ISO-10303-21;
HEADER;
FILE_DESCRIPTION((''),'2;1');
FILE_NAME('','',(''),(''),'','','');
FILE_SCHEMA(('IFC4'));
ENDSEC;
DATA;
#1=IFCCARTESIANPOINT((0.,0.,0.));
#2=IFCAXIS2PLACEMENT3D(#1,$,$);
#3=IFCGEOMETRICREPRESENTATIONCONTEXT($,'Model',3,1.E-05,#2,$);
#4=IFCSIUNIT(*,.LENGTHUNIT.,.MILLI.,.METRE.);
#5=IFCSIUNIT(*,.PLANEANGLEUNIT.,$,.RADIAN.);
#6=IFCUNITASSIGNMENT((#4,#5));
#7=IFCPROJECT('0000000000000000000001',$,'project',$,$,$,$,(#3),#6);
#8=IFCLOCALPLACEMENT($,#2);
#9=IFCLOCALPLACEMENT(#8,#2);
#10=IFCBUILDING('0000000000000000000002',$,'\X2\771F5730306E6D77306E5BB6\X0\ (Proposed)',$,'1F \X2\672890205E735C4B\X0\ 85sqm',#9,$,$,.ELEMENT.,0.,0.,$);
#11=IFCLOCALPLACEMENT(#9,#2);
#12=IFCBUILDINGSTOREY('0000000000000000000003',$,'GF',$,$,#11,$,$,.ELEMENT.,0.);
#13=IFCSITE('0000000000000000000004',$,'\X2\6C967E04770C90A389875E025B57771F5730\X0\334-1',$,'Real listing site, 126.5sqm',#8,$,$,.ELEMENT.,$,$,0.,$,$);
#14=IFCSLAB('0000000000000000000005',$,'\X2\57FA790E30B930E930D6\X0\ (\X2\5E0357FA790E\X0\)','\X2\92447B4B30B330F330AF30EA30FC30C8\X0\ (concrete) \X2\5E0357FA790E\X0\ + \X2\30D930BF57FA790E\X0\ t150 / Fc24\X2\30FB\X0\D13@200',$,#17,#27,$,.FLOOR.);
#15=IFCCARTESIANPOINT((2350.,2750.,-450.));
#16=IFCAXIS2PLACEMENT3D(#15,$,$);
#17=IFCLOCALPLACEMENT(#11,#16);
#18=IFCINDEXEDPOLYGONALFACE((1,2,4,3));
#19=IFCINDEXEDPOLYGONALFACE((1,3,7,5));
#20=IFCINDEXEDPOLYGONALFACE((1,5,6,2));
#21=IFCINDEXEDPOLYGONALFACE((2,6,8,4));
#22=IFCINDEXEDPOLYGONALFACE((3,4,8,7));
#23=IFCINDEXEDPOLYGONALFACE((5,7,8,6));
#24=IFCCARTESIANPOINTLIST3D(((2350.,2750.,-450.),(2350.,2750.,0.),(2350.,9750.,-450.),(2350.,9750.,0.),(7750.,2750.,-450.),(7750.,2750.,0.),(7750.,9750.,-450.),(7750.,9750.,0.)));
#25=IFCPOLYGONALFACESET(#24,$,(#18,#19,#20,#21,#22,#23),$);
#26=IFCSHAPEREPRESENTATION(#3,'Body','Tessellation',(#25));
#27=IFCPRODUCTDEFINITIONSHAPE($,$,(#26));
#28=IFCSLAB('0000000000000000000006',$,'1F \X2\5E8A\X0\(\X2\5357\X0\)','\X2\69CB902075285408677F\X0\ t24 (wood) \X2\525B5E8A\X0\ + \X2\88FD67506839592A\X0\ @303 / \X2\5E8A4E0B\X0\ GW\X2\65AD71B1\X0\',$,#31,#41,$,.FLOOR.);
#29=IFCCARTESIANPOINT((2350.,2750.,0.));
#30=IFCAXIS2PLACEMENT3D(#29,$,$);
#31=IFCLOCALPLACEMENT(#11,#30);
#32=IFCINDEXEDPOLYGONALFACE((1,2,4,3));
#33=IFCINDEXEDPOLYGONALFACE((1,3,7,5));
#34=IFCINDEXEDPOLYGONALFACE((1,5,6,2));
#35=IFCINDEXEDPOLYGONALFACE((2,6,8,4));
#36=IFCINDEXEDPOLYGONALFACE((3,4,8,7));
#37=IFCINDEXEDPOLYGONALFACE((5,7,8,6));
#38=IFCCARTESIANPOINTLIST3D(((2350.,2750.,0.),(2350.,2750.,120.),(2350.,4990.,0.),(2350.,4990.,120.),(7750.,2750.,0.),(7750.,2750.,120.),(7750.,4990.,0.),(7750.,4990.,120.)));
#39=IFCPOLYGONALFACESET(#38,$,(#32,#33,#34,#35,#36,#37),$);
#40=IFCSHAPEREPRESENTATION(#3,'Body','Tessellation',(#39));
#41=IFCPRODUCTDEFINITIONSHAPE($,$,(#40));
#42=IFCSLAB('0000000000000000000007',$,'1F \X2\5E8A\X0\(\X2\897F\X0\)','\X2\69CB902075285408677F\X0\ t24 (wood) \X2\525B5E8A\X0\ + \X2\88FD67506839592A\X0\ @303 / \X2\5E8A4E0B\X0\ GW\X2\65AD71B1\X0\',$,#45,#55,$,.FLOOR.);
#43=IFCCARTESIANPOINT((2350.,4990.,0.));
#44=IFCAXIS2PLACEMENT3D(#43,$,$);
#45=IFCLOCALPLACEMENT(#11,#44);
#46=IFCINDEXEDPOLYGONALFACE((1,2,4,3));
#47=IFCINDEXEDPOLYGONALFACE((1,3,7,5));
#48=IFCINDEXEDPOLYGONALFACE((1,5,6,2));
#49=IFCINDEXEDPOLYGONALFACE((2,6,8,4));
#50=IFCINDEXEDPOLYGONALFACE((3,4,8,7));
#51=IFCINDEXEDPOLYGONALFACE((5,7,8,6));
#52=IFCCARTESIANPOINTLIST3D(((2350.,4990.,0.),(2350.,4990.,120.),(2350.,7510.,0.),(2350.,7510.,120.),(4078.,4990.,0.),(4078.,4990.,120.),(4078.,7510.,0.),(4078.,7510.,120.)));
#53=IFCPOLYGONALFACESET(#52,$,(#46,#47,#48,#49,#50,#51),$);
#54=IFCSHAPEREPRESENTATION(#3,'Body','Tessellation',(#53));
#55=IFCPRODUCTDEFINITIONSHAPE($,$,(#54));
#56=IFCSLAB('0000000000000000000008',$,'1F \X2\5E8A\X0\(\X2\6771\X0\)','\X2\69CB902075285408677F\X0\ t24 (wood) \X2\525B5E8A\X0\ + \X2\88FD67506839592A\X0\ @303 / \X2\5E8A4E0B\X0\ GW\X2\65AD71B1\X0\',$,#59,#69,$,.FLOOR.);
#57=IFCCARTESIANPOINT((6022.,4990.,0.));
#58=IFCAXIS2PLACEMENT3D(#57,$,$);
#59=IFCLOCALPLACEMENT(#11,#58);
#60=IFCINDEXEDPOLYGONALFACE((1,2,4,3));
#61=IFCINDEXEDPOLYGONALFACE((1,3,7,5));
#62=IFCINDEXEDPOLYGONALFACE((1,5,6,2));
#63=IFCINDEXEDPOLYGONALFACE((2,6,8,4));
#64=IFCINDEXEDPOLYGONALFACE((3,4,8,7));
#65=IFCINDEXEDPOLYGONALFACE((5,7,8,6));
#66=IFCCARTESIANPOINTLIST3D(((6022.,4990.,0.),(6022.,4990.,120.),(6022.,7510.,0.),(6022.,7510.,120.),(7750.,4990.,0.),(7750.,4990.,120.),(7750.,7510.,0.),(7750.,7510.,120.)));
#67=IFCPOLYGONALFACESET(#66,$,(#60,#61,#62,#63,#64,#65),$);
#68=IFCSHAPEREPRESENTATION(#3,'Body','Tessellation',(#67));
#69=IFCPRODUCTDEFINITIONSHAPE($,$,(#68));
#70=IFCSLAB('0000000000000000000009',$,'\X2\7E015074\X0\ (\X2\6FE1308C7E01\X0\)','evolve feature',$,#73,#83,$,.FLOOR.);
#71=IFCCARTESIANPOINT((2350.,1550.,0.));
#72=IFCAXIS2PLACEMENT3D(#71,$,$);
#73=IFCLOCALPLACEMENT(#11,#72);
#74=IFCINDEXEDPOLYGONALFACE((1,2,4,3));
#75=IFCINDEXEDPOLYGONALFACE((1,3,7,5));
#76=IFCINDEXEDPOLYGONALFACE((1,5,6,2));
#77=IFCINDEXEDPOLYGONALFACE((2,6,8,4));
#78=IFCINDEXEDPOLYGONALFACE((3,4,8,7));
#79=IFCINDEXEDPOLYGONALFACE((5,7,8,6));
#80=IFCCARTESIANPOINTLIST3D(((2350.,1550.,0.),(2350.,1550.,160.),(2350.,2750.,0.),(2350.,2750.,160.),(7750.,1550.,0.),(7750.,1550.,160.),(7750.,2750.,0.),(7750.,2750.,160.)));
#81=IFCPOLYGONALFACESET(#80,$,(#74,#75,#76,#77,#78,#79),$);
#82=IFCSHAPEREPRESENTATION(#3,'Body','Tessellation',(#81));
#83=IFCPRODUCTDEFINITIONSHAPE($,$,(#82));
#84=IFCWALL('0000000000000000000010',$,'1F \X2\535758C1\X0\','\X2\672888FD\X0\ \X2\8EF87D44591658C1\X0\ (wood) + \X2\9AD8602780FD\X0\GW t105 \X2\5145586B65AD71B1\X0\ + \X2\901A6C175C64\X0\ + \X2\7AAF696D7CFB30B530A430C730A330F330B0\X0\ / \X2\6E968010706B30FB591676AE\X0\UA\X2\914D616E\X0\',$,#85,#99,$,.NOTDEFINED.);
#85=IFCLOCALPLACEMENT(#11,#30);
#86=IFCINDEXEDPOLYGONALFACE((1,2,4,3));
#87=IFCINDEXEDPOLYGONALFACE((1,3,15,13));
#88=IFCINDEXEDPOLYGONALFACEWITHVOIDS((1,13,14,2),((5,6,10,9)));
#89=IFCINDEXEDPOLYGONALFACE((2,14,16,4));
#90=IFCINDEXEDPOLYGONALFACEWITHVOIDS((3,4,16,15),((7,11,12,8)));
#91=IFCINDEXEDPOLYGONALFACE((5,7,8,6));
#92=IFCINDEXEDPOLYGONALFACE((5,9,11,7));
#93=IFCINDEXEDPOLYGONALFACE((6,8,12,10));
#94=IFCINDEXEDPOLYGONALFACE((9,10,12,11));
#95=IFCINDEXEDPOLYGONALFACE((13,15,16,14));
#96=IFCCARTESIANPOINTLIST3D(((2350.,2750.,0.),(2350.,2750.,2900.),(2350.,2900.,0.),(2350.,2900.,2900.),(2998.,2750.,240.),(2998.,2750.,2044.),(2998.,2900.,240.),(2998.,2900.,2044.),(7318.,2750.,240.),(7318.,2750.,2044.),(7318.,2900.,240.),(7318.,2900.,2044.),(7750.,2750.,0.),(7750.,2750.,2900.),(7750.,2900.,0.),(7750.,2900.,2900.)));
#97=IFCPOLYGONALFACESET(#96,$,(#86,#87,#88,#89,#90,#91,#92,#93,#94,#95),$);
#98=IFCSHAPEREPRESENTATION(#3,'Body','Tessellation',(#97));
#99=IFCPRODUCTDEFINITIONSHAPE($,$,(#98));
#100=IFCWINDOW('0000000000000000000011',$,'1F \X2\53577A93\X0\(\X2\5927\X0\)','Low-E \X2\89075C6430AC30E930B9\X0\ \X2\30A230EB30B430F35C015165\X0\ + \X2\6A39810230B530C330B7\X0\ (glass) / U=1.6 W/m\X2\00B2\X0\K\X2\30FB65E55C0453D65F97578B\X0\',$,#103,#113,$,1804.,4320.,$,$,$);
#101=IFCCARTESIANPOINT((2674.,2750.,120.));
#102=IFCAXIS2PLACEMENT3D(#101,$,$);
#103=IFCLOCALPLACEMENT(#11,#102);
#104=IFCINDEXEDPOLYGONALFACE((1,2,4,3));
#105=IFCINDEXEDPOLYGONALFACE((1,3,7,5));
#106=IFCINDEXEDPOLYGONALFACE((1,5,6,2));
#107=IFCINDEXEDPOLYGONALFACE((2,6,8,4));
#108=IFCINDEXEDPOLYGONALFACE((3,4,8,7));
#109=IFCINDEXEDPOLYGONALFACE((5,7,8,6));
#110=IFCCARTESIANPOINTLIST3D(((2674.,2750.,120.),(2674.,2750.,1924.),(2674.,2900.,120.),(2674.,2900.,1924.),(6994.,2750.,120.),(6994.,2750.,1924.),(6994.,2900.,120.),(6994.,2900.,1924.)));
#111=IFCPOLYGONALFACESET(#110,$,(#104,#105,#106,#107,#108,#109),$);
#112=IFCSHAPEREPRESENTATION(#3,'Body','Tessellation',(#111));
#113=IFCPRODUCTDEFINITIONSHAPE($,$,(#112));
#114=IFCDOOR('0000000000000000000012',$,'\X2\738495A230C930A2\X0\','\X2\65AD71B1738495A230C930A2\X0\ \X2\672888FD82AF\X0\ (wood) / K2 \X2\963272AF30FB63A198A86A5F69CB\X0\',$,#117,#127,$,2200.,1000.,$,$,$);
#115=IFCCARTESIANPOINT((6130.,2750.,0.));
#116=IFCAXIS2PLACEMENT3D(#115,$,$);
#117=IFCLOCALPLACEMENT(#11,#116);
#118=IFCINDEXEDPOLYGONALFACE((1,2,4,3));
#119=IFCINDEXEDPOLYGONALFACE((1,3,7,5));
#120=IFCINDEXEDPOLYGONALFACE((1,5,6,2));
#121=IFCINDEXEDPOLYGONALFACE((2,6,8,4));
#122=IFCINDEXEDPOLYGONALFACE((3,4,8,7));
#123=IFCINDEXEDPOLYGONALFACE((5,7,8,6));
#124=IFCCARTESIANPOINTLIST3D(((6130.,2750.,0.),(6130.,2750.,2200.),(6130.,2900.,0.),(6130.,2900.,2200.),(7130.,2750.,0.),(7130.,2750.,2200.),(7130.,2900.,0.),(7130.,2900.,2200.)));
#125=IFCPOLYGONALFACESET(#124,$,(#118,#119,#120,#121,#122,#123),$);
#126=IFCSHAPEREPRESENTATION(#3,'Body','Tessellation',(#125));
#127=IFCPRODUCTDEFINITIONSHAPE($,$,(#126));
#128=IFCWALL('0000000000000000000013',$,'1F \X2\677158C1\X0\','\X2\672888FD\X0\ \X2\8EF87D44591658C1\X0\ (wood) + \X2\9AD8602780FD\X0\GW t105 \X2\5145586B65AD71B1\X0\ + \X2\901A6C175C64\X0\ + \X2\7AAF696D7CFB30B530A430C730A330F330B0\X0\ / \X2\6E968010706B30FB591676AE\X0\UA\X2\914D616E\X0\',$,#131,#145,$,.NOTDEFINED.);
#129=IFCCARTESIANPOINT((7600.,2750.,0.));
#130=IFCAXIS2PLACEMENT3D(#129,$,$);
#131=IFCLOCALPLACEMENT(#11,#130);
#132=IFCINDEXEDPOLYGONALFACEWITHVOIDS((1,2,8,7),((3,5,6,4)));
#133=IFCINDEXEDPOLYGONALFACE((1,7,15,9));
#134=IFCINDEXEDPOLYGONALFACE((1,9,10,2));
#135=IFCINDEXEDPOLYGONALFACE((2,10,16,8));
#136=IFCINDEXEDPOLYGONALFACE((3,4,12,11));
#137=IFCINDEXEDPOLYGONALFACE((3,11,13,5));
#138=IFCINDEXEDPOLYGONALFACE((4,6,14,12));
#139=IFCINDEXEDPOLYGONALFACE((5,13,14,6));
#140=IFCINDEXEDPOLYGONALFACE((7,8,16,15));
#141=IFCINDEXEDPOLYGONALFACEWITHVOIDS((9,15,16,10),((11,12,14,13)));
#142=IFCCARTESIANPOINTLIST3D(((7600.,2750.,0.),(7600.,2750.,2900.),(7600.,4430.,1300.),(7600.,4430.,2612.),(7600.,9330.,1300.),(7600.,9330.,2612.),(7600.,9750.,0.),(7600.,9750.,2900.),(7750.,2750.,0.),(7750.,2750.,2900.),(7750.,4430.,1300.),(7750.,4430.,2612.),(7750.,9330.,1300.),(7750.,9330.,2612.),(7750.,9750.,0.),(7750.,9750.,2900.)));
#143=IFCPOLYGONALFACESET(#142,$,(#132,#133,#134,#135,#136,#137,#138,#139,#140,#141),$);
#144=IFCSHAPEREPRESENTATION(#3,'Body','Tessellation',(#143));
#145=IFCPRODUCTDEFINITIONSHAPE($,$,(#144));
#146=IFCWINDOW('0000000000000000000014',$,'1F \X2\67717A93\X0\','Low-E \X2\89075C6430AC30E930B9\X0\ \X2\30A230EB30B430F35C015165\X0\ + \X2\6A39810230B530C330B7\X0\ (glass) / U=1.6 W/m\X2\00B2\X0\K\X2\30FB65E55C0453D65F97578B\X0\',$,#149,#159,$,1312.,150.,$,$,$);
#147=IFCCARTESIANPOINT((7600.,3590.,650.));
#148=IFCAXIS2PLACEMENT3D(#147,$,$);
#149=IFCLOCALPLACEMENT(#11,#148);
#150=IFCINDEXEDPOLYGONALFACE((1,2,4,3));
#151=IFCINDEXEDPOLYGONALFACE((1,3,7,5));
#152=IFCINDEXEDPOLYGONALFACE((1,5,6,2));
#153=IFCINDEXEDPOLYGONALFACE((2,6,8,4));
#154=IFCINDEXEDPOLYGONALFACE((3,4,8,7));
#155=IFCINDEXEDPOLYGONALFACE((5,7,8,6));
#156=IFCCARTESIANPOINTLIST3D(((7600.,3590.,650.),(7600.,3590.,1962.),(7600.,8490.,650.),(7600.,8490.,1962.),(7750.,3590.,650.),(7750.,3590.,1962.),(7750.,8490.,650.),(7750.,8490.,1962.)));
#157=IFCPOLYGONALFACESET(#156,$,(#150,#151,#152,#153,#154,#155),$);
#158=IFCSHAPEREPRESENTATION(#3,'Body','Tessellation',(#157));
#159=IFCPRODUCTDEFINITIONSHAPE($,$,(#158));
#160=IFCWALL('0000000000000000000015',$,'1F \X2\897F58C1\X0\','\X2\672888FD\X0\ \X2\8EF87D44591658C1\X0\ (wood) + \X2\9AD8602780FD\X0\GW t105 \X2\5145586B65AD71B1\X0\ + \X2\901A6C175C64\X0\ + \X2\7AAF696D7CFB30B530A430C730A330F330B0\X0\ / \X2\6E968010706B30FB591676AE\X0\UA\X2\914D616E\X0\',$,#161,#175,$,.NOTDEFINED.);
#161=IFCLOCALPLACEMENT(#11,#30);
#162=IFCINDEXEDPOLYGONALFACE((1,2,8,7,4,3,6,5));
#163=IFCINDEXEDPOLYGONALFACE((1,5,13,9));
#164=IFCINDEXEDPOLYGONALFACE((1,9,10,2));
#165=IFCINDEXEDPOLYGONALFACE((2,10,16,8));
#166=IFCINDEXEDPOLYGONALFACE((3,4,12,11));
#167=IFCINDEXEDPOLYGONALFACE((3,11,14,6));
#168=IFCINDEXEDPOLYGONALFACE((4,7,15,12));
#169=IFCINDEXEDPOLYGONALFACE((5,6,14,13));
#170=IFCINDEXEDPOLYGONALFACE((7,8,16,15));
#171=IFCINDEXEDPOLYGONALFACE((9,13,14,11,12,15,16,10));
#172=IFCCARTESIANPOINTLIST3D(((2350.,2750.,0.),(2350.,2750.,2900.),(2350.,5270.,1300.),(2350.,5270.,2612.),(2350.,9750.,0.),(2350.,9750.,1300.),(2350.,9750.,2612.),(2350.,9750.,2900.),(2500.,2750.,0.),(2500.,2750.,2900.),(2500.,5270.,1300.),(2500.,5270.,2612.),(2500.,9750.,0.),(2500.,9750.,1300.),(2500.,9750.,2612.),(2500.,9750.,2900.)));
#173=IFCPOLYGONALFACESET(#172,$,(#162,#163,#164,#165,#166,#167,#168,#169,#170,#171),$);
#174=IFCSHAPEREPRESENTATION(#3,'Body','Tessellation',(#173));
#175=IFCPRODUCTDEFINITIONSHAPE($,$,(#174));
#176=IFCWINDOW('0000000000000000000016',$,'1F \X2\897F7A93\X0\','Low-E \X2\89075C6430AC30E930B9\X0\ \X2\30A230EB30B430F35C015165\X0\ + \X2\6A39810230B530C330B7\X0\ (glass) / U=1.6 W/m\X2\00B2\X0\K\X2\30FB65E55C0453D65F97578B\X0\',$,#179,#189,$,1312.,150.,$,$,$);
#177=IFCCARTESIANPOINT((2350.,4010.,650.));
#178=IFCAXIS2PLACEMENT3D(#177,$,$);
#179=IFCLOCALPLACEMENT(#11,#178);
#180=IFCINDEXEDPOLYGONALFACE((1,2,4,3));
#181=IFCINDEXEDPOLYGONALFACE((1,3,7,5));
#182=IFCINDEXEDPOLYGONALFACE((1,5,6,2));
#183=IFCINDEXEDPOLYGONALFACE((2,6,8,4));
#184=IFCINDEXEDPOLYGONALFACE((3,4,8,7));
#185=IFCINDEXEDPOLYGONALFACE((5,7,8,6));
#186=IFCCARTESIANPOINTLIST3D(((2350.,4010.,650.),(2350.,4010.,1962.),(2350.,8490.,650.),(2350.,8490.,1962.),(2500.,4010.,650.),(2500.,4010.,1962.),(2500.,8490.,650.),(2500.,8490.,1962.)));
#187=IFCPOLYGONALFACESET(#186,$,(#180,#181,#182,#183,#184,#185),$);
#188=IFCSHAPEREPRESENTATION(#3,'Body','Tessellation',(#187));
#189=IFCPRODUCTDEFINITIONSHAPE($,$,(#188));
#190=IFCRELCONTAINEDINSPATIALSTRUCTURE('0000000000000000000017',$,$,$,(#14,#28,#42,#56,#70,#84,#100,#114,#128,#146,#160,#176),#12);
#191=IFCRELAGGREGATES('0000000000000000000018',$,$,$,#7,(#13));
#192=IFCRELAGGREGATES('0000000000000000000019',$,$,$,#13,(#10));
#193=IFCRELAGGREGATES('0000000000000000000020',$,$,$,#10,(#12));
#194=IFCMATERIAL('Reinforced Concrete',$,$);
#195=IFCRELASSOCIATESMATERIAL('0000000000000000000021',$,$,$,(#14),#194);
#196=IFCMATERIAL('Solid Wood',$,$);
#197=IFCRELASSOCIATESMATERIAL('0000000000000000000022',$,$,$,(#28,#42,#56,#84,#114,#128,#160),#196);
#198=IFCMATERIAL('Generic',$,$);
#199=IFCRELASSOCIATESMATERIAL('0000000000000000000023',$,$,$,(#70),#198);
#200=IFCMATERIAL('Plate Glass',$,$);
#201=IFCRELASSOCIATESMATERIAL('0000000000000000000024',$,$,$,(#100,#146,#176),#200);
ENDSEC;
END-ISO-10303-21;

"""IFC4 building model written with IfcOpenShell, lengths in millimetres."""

from ifc_helpers import new_model, si_unit, frame, frame_2d, origin, place, context, project, spatial, rectangle, extrude, material, element, fill, save


model = new_model("IFC4")

# Units and contexts
model_context = context("Model", 3, precision=1e-05, world=origin())
ifc_project = project(units=[si_unit("LENGTHUNIT", "METRE", prefix="MILLI"), si_unit("PLANEANGLEUNIT", "RADIAN")], contexts=[model_context])

# Site, building, storey
site_placement = place(None, origin())
site = spatial("IfcSite", under=ifc_project, at=site_placement, Name="沖縄県那覇市字真地334-1", ObjectType="Real listing site, 126.5sqm", CompositionType="ELEMENT", RefElevation=0.0)
building_placement = place(site_placement, origin())
building = spatial("IfcBuilding", under=site, at=building_placement, Name="真地の海の家 (Proposed)", ObjectType="1F 木造平屋 85sqm", CompositionType="ELEMENT", ElevationOfRefHeight=0.0, ElevationOfTerrain=0.0)
storey_placement = place(building_placement, origin())
storey = spatial("IfcBuildingStorey", under=building, at=storey_placement, Name="GF", CompositionType="ELEMENT", Elevation=0.0)

# Slabs
ifc_material_1 = material(Name="Reinforced Concrete")
slab_1_placement = place(storey_placement, frame((2350.0, 2750.0, -450.0)))
element("IfcSlab", 1, at=slab_1_placement, inside=storey, material=ifc_material_1, Name="基礎スラブ (布基礎)", Description="鉄筋コンクリート (concrete) 布基礎 + ベタ基礎 t150 / Fc24・D13@200", PredefinedType="FLOOR", context=model_context, shape_type="SweptSolid", body=[
    extrude(rectangle(XDim=5400.0, YDim=7000.0, at=frame_2d((2700.0, 3500.0))), frame((2350.0, 2750.0, -450.0)), (0.0, 0.0, 1.0), 450.0),
])
ifc_material_2 = material(Name="Solid Wood")
slab_2_placement = place(storey_placement, frame((2350.0, 2750.0, 0.0)))
element("IfcSlab", 2, at=slab_2_placement, inside=storey, material=ifc_material_2, Name="1F 床(南)", Description="構造用合板 t24 (wood) 剛床 + 製材根太 @303 / 床下 GW断熱", PredefinedType="FLOOR", context=model_context, shape_type="SweptSolid", body=[
    extrude(rectangle(XDim=5400.0, YDim=2240.0, at=frame_2d((2700.0, 1120.0))), frame((2350.0, 2750.0, 0.0)), (0.0, 0.0, 1.0), 120.0),
])
slab_3_placement = place(storey_placement, frame((2350.0, 4990.0, 0.0)))
element("IfcSlab", 3, at=slab_3_placement, inside=storey, material=ifc_material_2, Name="1F 床(西)", Description="構造用合板 t24 (wood) 剛床 + 製材根太 @303 / 床下 GW断熱", PredefinedType="FLOOR", context=model_context, shape_type="SweptSolid", body=[
    extrude(rectangle(XDim=1728.0, YDim=2520.0, at=frame_2d((864.0, 1260.0))), frame((2350.0, 4990.0, 0.0)), (0.0, 0.0, 1.0), 120.0),
])
slab_4_placement = place(storey_placement, frame((6022.0, 4990.0, 0.0)))
element("IfcSlab", 4, at=slab_4_placement, inside=storey, material=ifc_material_2, Name="1F 床(東)", Description="構造用合板 t24 (wood) 剛床 + 製材根太 @303 / 床下 GW断熱", PredefinedType="FLOOR", context=model_context, shape_type="SweptSolid", body=[
    extrude(rectangle(XDim=1728.0, YDim=2520.0, at=frame_2d((864.0, 1260.0))), frame((6022.0, 4990.0, 0.0)), (0.0, 0.0, 1.0), 120.0),
])
ifc_material_3 = material(Name="Generic")
slab_5_placement = place(storey_placement, frame((2350.0, 1550.0, 0.0)))
element("IfcSlab", 5, at=slab_5_placement, inside=storey, material=ifc_material_3, Name="縁側 (濡れ縁)", Description="evolve feature", PredefinedType="FLOOR", context=model_context, shape_type="SweptSolid", body=[
    extrude(rectangle(XDim=5400.0, YDim=1200.0, at=frame_2d((2700.0, 600.0))), frame((2350.0, 1550.0, 0.0)), (0.0, 0.0, 1.0), 160.0),
])

# Wall, openings, window, door
wall_1_placement = place(storey_placement, frame((2350.0, 2750.0, 0.0)))
wall_1 = element("IfcWall", 6, at=wall_1_placement, inside=storey, material=ifc_material_2, Name="1F 南壁", Description="木製 軸組外壁 (wood) + 高性能GW t105 充填断熱 + 通気層 + 窯業系サイディング / 準耐火・外皮UA配慮", PredefinedType="NOTDEFINED", context=model_context, shape_type="SweptSolid", body=[
    extrude(rectangle(XDim=5400.0, YDim=150.0, at=frame_2d((2700.0, 75.0))), frame((2350.0, 2750.0, 0.0)), (0.0, 0.0, 1.0), 2900.0),
])
opening_1_placement = place(storey_placement, frame((2674.0, 2750.0, 120.0)))
opening_1 = element("IfcOpeningElement", 7, at=opening_1_placement, cuts=wall_1, PredefinedType="NOTDEFINED", context=model_context, shape_type="SweptSolid", body=[
    extrude(rectangle(XDim=4320.0, YDim=150.0, at=frame_2d((2160.0, 75.0))), frame((2674.0, 2750.0, 120.0)), (0.0, 0.0, 1.0), 1804.0),
])
opening_2_placement = place(storey_placement, frame((6130.0, 2750.0, 0.0)))
opening_2 = element("IfcOpeningElement", 8, at=opening_2_placement, cuts=wall_1, PredefinedType="NOTDEFINED", context=model_context, shape_type="SweptSolid", body=[
    extrude(rectangle(XDim=1000.0, YDim=150.0, at=frame_2d((500.0, 75.0))), frame((6130.0, 2750.0, 0.0)), (0.0, 0.0, 1.0), 2200.0),
])
ifc_material_4 = material(Name="Plate Glass")
window_1_placement = place(storey_placement, frame((2674.0, 2750.0, 120.0)))
window_1 = element("IfcWindow", 9, at=window_1_placement, inside=storey, material=ifc_material_4, Name="1F 南窓(大)", Description="Low-E 複層ガラス アルゴン封入 + 樹脂サッシ (glass) / U=1.6 W/m²K・日射取得型", OverallHeight=1804.0, OverallWidth=4320.0, context=model_context, shape_type="SweptSolid", body=[
    extrude(rectangle(XDim=4320.0, YDim=150.0, at=frame_2d((2160.0, 75.0))), frame((2674.0, 2750.0, 120.0)), (0.0, 0.0, 1.0), 1804.0),
])
fill(opening_1, window_1)
door_placement = place(storey_placement, frame((6130.0, 2750.0, 0.0)))
door = element("IfcDoor", 10, at=door_placement, inside=storey, material=ifc_material_2, Name="玄関ドア", Description="断熱玄関ドア 木製芯 (wood) / K2 防犯・採風機構", OverallHeight=2200.0, OverallWidth=1000.0, context=model_context, shape_type="SweptSolid", body=[
    extrude(rectangle(XDim=1000.0, YDim=150.0, at=frame_2d((500.0, 75.0))), frame((6130.0, 2750.0, 0.0)), (0.0, 0.0, 1.0), 2200.0),
])
fill(opening_2, door)

# Walls, openings, windows
wall_2_placement = place(storey_placement, frame((7600.0, 2750.0, 0.0)))
wall_2 = element("IfcWall", 11, at=wall_2_placement, inside=storey, material=ifc_material_2, Name="1F 東壁", Description="木製 軸組外壁 (wood) + 高性能GW t105 充填断熱 + 通気層 + 窯業系サイディング / 準耐火・外皮UA配慮", PredefinedType="NOTDEFINED", context=model_context, shape_type="SweptSolid", body=[
    extrude(rectangle(XDim=150.0, YDim=7000.0, at=frame_2d((75.0, 3500.0))), frame((7600.0, 2750.0, 0.0)), (0.0, 0.0, 1.0), 2900.0),
])
opening_3_placement = place(storey_placement, frame((7600.0, 3590.0, 650.0)))
opening_3 = element("IfcOpeningElement", 12, at=opening_3_placement, cuts=wall_2, PredefinedType="NOTDEFINED", context=model_context, shape_type="SweptSolid", body=[
    extrude(rectangle(XDim=150.0, YDim=4900.0, at=frame_2d((75.0, 2450.0))), frame((7600.0, 3590.0, 650.0)), (0.0, 0.0, 1.0), 1312.0),
])
window_2_placement = place(storey_placement, frame((7600.0, 3590.0, 650.0)))
window_2 = element("IfcWindow", 13, at=window_2_placement, inside=storey, material=ifc_material_4, Name="1F 東窓", Description="Low-E 複層ガラス アルゴン封入 + 樹脂サッシ (glass) / U=1.6 W/m²K・日射取得型", OverallHeight=1312.0, OverallWidth=150.0, context=model_context, shape_type="SweptSolid", body=[
    extrude(rectangle(XDim=150.0, YDim=4900.0, at=frame_2d((75.0, 2450.0))), frame((7600.0, 3590.0, 650.0)), (0.0, 0.0, 1.0), 1312.0),
])
fill(opening_3, window_2)
wall_3_placement = place(storey_placement, frame((2350.0, 2750.0, 0.0)))
wall_3 = element("IfcWall", 14, at=wall_3_placement, inside=storey, material=ifc_material_2, Name="1F 西壁", Description="木製 軸組外壁 (wood) + 高性能GW t105 充填断熱 + 通気層 + 窯業系サイディング / 準耐火・外皮UA配慮", PredefinedType="NOTDEFINED", context=model_context, shape_type="SweptSolid", body=[
    extrude(rectangle(XDim=150.0, YDim=7000.0, at=frame_2d((75.0, 3500.0))), frame((2350.0, 2750.0, 0.0)), (0.0, 0.0, 1.0), 2900.0),
])
opening_4_placement = place(storey_placement, frame((2350.0, 4010.0, 650.0)))
opening_4 = element("IfcOpeningElement", 15, at=opening_4_placement, cuts=wall_3, PredefinedType="NOTDEFINED", context=model_context, shape_type="SweptSolid", body=[
    extrude(rectangle(XDim=150.0, YDim=4480.0, at=frame_2d((75.0, 2240.0))), frame((2350.0, 4010.0, 650.0)), (0.0, 0.0, 1.0), 1312.0),
])
window_3_placement = place(storey_placement, frame((2350.0, 4010.0, 650.0)))
window_3 = element("IfcWindow", 16, at=window_3_placement, inside=storey, material=ifc_material_4, Name="1F 西窓", Description="Low-E 複層ガラス アルゴン封入 + 樹脂サッシ (glass) / U=1.6 W/m²K・日射取得型", OverallHeight=1312.0, OverallWidth=150.0, context=model_context, shape_type="SweptSolid", body=[
    extrude(rectangle(XDim=150.0, YDim=4480.0, at=frame_2d((75.0, 2240.0))), frame((2350.0, 4010.0, 650.0)), (0.0, 0.0, 1.0), 1312.0),
])
fill(opening_4, window_3)

save(model, "model.ifc")
